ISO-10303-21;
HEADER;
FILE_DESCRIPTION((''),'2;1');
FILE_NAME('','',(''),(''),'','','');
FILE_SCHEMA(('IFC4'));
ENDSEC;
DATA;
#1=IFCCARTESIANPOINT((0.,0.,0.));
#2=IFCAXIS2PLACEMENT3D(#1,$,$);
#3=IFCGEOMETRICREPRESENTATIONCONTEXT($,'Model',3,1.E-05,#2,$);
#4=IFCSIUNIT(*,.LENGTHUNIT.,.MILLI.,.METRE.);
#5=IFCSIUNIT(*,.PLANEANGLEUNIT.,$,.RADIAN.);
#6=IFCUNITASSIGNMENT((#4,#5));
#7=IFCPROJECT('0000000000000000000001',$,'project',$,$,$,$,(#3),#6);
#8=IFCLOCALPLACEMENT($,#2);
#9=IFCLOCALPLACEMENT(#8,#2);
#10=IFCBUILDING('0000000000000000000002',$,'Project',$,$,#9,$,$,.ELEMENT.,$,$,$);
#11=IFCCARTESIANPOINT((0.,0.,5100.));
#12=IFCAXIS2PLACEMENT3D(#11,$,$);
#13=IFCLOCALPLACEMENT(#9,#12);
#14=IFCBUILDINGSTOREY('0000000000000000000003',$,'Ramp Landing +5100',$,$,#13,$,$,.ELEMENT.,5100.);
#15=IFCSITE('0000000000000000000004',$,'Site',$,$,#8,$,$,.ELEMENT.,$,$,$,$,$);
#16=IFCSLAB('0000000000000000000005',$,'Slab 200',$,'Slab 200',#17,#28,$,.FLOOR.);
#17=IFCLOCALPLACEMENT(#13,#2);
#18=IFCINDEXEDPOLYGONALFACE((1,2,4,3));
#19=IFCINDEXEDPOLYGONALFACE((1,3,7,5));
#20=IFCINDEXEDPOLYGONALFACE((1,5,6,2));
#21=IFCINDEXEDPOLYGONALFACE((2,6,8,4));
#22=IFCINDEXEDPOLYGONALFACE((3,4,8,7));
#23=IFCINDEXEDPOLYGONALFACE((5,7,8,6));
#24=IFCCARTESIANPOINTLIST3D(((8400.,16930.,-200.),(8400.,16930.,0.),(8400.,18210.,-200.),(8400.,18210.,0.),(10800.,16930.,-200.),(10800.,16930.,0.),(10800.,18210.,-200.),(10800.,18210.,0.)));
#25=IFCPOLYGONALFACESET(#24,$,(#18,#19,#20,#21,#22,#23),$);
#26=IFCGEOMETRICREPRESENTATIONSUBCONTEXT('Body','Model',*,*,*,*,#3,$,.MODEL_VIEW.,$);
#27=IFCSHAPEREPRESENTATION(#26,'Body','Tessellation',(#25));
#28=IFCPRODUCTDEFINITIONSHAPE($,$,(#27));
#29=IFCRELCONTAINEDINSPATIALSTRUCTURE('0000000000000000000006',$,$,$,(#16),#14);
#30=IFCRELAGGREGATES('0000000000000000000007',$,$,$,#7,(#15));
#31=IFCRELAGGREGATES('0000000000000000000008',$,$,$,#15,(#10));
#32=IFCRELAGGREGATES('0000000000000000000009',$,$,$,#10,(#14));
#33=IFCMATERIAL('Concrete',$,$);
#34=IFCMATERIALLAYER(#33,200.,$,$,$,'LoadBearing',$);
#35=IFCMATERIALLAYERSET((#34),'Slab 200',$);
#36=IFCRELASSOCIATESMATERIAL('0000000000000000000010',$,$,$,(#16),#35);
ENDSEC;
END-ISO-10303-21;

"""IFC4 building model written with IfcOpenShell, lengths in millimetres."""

from ifc_helpers import new_model, si_unit, frame, origin, place, context, subcontext, project, spatial, polyline, outline, extrude, material, layer, layer_set, layer_usage, element, save


model = new_model("IFC4")

# Units and contexts
model_context = context("Model", 3, precision=1e-05, world=origin())
body_context = subcontext(model_context, "Body", "Model", "MODEL_VIEW")
ifc_project = project(units=[si_unit("LENGTHUNIT", "METRE", prefix="MILLI"), si_unit("PLANEANGLEUNIT", "RADIAN")], contexts=[model_context])

# Site, building, storey
site_placement = place(None, origin())
site = spatial("IfcSite", under=ifc_project, at=site_placement, Name="Site", CompositionType="ELEMENT")
building_placement = place(site_placement, origin())
building = spatial("IfcBuilding", under=site, at=building_placement, Name="Project", CompositionType="ELEMENT")
storey_placement = place(building_placement, frame((0.0, 0.0, 5100.0)))
storey = spatial("IfcBuildingStorey", under=building, at=storey_placement, Name="Ramp Landing +5100", CompositionType="ELEMENT", Elevation=5100.0)

# Slab
ifc_material = material(Name="Concrete")
ifc_layer = layer(ifc_material, 200.0, Category="LoadBearing")
ifc_layer_set = layer_set([ifc_layer], Name="Slab 200")
ifc_layer_usage = layer_usage(ifc_layer_set, "AXIS3", "NEGATIVE", 0.0)
slab_placement = place(storey_placement, origin())
element("IfcSlab", 1, at=slab_placement, inside=storey, material=ifc_layer_usage, Name="Slab 200", ObjectType="Slab 200", PredefinedType="FLOOR", context=body_context, shape_type="SweptSolid", body=[
    extrude(outline(polyline([(8400.0, 16930.0), (10800.0, 16930.0), (10800.0, 18210.0), (8400.0, 18210.0), (8400.0, 16930.0)])), frame((0.0, 0.0, -200.0)), (0.0, 0.0, 1.0), 200.0),
])

save(model, "model.ifc")
